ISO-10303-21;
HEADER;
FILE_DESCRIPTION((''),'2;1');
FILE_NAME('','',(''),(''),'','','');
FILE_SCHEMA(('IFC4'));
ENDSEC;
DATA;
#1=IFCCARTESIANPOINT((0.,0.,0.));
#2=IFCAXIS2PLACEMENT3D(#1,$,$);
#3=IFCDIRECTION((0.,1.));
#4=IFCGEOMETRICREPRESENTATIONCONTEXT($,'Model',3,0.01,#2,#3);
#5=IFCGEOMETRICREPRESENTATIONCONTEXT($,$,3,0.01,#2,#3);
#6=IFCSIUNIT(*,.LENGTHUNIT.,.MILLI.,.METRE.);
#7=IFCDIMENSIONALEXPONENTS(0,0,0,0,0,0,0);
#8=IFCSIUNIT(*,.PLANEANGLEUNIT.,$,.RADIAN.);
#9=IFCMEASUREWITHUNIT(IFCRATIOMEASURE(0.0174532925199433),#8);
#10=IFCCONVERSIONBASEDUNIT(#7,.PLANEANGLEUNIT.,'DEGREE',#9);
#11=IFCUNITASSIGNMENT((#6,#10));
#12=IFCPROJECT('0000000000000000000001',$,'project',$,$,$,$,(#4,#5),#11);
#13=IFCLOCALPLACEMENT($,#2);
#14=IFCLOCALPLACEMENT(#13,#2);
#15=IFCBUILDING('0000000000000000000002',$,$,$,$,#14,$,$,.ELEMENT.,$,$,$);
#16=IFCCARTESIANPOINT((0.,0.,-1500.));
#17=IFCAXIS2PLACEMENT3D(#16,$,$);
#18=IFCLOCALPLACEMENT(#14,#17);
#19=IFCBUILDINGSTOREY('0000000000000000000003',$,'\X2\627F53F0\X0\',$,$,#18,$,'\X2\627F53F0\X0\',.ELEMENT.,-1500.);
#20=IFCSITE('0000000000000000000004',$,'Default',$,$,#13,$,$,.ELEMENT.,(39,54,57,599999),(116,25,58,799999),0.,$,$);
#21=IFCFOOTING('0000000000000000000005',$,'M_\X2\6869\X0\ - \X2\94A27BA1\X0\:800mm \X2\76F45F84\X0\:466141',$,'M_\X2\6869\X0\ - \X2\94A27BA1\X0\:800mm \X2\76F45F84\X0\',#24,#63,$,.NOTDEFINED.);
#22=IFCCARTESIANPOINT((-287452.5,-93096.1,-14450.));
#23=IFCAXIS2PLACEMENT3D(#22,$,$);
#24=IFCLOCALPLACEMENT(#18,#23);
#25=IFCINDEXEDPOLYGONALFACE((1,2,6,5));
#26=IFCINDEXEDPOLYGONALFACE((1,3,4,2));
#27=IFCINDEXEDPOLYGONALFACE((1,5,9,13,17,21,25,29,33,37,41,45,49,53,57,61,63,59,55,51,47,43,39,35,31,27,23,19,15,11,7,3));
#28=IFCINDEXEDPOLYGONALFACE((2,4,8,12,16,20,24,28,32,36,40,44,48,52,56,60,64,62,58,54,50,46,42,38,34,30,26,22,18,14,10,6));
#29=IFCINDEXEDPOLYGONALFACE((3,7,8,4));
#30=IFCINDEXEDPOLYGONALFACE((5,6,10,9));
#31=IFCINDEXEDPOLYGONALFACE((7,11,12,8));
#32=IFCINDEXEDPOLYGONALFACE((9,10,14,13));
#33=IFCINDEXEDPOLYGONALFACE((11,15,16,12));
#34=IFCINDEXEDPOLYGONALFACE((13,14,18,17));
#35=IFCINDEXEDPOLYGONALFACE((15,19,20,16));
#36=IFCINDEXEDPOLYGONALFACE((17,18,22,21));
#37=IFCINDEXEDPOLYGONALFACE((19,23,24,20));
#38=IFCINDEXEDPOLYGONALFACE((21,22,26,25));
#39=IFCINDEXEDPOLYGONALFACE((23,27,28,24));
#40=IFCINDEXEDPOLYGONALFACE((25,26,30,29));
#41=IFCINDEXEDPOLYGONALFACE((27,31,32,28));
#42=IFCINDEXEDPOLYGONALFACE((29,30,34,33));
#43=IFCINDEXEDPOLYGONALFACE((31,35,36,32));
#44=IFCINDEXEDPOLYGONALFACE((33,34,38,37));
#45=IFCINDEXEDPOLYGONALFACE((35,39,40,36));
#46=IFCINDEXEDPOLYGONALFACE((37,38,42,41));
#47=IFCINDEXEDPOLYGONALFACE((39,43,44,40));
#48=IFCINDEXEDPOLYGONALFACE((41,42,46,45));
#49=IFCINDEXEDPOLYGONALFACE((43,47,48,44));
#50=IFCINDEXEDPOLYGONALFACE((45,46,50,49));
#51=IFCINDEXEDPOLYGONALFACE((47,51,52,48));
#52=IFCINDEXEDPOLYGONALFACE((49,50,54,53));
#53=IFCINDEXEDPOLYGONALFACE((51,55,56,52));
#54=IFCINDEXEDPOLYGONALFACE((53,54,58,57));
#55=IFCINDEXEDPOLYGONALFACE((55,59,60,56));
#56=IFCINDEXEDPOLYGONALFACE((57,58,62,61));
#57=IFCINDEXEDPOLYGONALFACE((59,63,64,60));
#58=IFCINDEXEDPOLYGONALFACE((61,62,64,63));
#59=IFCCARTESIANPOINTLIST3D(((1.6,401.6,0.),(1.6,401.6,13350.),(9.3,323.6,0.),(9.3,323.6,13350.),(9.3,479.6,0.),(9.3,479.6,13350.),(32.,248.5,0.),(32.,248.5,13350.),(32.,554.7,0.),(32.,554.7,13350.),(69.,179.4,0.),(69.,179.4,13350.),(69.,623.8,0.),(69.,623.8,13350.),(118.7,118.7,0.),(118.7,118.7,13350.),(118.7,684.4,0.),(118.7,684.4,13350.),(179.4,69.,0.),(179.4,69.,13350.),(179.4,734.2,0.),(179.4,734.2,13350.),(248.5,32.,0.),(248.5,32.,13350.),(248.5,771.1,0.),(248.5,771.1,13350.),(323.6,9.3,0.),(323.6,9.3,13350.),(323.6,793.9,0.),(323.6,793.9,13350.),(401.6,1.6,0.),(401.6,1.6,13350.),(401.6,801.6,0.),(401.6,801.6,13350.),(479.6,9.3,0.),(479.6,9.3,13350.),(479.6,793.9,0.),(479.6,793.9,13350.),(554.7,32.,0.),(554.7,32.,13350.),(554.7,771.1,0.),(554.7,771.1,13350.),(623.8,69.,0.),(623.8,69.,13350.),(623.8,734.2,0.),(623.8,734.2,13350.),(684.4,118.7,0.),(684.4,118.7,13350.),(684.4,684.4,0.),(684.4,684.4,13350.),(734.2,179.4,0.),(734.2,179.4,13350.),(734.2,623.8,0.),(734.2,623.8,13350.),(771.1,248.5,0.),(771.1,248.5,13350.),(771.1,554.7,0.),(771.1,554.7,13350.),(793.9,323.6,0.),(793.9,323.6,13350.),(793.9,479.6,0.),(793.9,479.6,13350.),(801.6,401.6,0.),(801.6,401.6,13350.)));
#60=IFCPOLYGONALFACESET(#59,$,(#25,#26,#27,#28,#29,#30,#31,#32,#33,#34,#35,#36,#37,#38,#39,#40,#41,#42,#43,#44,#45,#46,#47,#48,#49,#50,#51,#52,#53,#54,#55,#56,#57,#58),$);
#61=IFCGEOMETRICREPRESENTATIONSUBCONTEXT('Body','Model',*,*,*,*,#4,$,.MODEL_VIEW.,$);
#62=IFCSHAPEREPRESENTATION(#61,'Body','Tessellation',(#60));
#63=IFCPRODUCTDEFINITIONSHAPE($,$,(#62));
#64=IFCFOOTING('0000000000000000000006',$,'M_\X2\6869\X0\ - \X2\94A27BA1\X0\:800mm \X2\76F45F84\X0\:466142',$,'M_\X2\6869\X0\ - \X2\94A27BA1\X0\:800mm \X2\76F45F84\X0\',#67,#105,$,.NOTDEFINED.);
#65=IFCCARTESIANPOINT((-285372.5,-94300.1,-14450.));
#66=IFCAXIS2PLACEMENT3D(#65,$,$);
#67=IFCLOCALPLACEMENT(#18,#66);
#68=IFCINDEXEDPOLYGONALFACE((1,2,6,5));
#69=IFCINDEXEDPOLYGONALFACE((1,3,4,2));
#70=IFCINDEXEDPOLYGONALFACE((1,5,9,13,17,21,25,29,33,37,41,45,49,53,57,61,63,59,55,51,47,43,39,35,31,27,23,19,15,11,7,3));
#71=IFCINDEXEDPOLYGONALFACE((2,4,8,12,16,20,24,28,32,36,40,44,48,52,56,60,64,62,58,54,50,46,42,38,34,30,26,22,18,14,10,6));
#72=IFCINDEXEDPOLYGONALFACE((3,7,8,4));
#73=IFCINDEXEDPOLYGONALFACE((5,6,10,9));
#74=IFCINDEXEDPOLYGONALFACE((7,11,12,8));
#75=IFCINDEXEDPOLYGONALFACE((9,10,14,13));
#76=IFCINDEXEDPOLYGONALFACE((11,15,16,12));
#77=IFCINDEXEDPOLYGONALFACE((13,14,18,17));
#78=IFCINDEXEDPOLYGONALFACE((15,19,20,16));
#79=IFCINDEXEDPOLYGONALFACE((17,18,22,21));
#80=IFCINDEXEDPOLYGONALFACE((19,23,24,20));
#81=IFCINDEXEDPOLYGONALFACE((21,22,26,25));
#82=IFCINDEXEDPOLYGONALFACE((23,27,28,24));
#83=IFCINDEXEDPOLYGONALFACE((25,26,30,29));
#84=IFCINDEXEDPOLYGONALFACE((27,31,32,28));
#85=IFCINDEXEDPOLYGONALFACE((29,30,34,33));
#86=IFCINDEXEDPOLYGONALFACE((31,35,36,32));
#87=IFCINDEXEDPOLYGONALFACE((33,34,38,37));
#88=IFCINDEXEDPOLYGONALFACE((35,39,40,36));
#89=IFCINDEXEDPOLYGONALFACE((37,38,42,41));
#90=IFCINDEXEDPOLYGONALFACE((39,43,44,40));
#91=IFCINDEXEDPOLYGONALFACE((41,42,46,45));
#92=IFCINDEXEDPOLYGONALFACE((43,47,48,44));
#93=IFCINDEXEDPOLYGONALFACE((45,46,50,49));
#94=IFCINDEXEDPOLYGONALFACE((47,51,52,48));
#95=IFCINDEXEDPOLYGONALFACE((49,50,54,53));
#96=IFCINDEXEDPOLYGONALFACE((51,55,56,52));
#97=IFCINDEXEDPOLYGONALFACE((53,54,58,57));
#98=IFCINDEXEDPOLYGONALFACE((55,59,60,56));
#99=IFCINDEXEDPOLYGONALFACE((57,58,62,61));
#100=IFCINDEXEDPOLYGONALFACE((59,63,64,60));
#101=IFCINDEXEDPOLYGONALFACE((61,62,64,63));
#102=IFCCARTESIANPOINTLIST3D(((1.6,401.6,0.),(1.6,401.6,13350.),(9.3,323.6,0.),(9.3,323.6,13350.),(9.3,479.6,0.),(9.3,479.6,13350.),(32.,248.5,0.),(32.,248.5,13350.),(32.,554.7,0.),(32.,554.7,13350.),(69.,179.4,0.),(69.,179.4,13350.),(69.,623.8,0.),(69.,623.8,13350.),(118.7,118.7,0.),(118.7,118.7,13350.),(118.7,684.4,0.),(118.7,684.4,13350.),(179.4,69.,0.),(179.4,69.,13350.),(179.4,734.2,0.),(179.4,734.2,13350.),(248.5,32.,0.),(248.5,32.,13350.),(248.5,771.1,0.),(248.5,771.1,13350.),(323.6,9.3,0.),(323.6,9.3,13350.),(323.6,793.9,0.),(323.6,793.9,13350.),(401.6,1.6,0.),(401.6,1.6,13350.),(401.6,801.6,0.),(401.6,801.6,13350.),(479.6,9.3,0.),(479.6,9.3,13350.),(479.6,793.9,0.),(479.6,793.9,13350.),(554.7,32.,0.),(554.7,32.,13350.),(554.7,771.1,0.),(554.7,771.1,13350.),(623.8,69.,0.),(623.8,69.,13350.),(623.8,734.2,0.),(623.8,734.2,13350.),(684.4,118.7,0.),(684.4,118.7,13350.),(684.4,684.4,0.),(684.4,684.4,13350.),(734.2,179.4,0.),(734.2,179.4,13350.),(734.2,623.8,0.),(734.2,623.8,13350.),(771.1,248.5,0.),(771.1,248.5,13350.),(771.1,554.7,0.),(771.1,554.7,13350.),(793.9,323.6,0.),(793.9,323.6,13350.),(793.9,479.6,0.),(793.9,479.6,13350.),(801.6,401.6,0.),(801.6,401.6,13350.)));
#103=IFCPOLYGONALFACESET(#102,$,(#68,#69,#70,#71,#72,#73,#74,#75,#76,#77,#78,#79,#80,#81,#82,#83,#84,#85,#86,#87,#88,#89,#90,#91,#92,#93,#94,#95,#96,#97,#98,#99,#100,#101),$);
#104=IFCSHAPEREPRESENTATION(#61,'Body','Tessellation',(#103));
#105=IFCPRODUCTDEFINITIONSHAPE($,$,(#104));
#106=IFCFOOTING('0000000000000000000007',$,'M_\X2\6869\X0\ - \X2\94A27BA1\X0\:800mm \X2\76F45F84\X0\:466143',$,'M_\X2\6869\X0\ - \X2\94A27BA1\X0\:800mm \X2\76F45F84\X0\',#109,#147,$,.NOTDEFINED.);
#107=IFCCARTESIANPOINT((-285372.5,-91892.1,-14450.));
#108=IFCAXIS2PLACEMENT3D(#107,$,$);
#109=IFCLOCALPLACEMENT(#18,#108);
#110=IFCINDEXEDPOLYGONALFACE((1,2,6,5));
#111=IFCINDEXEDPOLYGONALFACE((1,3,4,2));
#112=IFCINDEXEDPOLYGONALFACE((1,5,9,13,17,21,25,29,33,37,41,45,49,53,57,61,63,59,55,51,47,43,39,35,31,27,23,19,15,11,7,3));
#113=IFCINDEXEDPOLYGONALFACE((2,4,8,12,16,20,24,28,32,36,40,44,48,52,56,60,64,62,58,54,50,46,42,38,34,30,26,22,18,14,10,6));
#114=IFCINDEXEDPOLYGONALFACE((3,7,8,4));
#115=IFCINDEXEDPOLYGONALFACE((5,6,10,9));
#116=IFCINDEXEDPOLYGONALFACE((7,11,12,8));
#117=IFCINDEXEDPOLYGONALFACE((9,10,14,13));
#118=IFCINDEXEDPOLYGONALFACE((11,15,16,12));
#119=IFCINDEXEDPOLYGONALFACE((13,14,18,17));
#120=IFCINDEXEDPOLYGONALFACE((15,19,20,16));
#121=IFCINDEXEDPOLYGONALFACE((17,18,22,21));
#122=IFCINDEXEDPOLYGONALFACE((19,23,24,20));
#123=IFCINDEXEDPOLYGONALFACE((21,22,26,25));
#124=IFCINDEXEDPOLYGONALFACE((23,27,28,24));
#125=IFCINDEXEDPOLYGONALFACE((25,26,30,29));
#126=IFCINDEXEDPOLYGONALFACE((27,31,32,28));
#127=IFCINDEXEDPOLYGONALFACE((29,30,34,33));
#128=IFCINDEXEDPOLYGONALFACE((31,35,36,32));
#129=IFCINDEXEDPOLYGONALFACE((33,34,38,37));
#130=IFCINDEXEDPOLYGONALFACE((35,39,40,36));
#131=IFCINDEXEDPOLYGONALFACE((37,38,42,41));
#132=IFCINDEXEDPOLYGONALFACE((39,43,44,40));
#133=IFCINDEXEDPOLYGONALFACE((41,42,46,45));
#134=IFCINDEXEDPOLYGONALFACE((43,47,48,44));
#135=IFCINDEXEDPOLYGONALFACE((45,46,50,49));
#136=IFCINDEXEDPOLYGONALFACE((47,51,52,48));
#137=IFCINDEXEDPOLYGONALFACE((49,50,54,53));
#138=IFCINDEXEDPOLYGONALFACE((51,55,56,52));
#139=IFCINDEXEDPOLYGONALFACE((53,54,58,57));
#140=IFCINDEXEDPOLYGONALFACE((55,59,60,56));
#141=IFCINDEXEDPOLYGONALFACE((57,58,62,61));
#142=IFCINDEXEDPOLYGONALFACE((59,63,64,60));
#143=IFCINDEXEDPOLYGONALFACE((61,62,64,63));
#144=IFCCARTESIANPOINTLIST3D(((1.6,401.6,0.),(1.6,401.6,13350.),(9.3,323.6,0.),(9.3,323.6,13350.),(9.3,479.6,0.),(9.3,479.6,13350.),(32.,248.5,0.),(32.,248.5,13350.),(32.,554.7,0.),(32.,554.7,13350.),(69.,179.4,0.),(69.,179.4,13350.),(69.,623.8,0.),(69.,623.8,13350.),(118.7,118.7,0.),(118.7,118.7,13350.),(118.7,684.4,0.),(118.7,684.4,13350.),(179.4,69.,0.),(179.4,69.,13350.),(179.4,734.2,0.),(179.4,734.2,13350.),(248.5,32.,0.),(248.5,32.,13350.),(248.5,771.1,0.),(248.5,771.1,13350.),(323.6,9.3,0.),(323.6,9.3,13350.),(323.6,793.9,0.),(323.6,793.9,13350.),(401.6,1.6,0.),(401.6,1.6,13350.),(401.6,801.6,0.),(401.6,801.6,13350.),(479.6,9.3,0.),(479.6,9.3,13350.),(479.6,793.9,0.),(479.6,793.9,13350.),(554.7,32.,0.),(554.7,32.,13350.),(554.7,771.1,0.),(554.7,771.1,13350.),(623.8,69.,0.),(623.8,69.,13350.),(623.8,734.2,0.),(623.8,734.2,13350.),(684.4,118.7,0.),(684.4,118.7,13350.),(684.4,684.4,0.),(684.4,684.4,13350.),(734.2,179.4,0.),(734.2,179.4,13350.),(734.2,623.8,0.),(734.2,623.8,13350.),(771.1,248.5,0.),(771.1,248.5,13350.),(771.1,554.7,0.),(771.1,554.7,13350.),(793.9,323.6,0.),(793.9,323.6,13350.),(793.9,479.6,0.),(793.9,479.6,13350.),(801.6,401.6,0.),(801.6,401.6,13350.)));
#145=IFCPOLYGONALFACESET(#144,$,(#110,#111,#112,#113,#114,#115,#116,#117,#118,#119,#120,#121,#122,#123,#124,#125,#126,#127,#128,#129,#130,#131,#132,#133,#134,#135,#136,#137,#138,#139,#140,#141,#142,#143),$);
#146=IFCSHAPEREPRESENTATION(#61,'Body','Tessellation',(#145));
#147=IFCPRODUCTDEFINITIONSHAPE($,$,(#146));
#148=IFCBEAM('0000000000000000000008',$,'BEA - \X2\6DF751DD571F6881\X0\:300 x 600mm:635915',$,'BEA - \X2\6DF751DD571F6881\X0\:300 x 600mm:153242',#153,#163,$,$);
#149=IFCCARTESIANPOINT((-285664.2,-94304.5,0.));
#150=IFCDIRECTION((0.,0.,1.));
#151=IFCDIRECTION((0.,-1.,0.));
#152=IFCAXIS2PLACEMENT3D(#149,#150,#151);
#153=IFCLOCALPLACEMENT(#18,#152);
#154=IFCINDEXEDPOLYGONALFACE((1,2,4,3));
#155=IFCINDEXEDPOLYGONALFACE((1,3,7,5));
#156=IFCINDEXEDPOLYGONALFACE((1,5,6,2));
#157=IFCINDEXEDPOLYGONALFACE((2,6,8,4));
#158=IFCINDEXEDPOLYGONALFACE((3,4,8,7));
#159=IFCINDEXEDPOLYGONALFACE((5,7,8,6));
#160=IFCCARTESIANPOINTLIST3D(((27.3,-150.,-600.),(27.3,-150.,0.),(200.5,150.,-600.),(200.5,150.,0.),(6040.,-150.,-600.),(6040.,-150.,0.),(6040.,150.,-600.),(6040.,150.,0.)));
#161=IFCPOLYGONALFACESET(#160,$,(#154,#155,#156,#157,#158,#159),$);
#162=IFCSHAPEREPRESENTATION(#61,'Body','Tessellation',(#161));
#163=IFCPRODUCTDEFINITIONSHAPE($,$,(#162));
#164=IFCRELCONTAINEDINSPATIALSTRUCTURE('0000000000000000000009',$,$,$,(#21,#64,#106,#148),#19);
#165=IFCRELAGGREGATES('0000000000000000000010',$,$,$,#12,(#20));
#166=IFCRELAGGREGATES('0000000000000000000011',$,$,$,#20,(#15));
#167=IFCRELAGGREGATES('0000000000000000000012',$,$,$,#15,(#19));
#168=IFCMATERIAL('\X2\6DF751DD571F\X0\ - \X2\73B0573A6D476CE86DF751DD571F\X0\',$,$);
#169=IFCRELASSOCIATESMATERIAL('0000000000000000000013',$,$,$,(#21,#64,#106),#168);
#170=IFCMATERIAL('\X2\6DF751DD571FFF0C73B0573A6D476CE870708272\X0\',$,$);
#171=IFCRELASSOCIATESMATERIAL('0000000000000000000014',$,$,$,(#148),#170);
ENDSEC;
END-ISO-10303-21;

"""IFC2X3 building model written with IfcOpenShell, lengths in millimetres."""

from ifc_helpers import new_model, entity, si_unit, converted_unit, direction, frame, frame_2d, origin, origin_2d_with_axis, place, context, subcontext, project, spatial, rectangle, circle, extrude, clip, halfspace, material, element, save


model = new_model("IFC2X3")

# Units and contexts
model_context = context("Model", 3, precision=0.01, world=origin(), true_north=direction((0.0, 1.0)))
context_of_model = context(None, 3, precision=0.01, world=origin(), true_north=direction((0.0, 1.0)))
body_context = subcontext(model_context, "Body", "Model", "MODEL_VIEW")
ifc_project = project(units=[si_unit("LENGTHUNIT", "METRE", prefix="MILLI"), converted_unit("PLANEANGLEUNIT", "DEGREE", entity("IfcRatioMeasure", 0.0174532925199433), si_unit("PLANEANGLEUNIT", "RADIAN"), dimensions=[0, 0, 0, 0, 0, 0, 0])], contexts=[model_context, context_of_model])

# Site, building, storey
site_placement = place(None, origin())
site = spatial("IfcSite", under=ifc_project, at=site_placement, Name="Default", CompositionType="ELEMENT", RefLatitude=(39, 54, 57, 599999), RefLongitude=(116, 25, 58, 799999), RefElevation=0.0)
building_placement = place(site_placement, origin())
building = spatial("IfcBuilding", under=site, at=building_placement, CompositionType="ELEMENT")
storey_placement = place(building_placement, frame((0.0, 0.0, -1500.0)))
storey = spatial("IfcBuildingStorey", under=building, at=storey_placement, Name="承台", LongName="承台", CompositionType="ELEMENT", Elevation=-1500.0)

# Footings
ifc_material_1 = material(Name="混凝土 - 现场浇注混凝土")
for number, where, name in (
    (1, (-287452.5, -93096.1, -14450.0), "M_桩 - 钢管:800mm 直径:466141"),
    (2, (-285372.5, -94300.1, -14450.0), "M_桩 - 钢管:800mm 直径:466142"),
    (3, (-285372.5, -91892.1, -14450.0), "M_桩 - 钢管:800mm 直径:466143"),
):
    element("IfcFooting", number, at=place(storey_placement, frame(where)), inside=storey, material=ifc_material_1, Name=name, ObjectType="M_桩 - 钢管:800mm 直径", PredefinedType="NOTDEFINED", context=body_context, shape_type="SweptSolid", body=[
        extrude(circle(Radius=400.0, at=origin_2d_with_axis()), frame((401.6, 401.6, 0.0), z_axis=(0.0, 0.0, 1.0), x_axis=(0.0, 1.0, 0.0)), (0.0, 0.0, 1.0), 13350.0),
    ])

# Shared definitions
ifc_material_2 = material(Name="混凝土，现场浇注灰色")

# Beam
beam_1_placement = place(storey_placement, frame((-285664.2, -94304.5, 0.0), z_axis=(0.0, 0.0, 1.0), x_axis=(0.0, -1.0, 0.0)))
element("IfcBeam", 4, at=beam_1_placement, inside=storey, material=ifc_material_2, Name="BEA - 混凝土梁:300 x 600mm:635915", ObjectType="BEA - 混凝土梁:300 x 600mm:153242", context=body_context, shape_type="Clipping", body=[
    clip(extrude(rectangle(XDim=600.0, YDim=300.0, at=frame_2d((0.0, 0.0), x_axis=(1.0, 0.0))), frame((27.3, 0.0, -300.0), z_axis=(1.0, 0.0, 0.0), x_axis=(0.0, 0.0, -1.0)), (0.0, 0.0, 1.0), 6012.7), halfspace(frame((-1148.0, -2186.7, 0.0), z_axis=(-0.866125, 0.499827, 0.0), x_axis=(0.499827, 0.866125, 0.0)), False)),
])

save(model, "model.ifc")
